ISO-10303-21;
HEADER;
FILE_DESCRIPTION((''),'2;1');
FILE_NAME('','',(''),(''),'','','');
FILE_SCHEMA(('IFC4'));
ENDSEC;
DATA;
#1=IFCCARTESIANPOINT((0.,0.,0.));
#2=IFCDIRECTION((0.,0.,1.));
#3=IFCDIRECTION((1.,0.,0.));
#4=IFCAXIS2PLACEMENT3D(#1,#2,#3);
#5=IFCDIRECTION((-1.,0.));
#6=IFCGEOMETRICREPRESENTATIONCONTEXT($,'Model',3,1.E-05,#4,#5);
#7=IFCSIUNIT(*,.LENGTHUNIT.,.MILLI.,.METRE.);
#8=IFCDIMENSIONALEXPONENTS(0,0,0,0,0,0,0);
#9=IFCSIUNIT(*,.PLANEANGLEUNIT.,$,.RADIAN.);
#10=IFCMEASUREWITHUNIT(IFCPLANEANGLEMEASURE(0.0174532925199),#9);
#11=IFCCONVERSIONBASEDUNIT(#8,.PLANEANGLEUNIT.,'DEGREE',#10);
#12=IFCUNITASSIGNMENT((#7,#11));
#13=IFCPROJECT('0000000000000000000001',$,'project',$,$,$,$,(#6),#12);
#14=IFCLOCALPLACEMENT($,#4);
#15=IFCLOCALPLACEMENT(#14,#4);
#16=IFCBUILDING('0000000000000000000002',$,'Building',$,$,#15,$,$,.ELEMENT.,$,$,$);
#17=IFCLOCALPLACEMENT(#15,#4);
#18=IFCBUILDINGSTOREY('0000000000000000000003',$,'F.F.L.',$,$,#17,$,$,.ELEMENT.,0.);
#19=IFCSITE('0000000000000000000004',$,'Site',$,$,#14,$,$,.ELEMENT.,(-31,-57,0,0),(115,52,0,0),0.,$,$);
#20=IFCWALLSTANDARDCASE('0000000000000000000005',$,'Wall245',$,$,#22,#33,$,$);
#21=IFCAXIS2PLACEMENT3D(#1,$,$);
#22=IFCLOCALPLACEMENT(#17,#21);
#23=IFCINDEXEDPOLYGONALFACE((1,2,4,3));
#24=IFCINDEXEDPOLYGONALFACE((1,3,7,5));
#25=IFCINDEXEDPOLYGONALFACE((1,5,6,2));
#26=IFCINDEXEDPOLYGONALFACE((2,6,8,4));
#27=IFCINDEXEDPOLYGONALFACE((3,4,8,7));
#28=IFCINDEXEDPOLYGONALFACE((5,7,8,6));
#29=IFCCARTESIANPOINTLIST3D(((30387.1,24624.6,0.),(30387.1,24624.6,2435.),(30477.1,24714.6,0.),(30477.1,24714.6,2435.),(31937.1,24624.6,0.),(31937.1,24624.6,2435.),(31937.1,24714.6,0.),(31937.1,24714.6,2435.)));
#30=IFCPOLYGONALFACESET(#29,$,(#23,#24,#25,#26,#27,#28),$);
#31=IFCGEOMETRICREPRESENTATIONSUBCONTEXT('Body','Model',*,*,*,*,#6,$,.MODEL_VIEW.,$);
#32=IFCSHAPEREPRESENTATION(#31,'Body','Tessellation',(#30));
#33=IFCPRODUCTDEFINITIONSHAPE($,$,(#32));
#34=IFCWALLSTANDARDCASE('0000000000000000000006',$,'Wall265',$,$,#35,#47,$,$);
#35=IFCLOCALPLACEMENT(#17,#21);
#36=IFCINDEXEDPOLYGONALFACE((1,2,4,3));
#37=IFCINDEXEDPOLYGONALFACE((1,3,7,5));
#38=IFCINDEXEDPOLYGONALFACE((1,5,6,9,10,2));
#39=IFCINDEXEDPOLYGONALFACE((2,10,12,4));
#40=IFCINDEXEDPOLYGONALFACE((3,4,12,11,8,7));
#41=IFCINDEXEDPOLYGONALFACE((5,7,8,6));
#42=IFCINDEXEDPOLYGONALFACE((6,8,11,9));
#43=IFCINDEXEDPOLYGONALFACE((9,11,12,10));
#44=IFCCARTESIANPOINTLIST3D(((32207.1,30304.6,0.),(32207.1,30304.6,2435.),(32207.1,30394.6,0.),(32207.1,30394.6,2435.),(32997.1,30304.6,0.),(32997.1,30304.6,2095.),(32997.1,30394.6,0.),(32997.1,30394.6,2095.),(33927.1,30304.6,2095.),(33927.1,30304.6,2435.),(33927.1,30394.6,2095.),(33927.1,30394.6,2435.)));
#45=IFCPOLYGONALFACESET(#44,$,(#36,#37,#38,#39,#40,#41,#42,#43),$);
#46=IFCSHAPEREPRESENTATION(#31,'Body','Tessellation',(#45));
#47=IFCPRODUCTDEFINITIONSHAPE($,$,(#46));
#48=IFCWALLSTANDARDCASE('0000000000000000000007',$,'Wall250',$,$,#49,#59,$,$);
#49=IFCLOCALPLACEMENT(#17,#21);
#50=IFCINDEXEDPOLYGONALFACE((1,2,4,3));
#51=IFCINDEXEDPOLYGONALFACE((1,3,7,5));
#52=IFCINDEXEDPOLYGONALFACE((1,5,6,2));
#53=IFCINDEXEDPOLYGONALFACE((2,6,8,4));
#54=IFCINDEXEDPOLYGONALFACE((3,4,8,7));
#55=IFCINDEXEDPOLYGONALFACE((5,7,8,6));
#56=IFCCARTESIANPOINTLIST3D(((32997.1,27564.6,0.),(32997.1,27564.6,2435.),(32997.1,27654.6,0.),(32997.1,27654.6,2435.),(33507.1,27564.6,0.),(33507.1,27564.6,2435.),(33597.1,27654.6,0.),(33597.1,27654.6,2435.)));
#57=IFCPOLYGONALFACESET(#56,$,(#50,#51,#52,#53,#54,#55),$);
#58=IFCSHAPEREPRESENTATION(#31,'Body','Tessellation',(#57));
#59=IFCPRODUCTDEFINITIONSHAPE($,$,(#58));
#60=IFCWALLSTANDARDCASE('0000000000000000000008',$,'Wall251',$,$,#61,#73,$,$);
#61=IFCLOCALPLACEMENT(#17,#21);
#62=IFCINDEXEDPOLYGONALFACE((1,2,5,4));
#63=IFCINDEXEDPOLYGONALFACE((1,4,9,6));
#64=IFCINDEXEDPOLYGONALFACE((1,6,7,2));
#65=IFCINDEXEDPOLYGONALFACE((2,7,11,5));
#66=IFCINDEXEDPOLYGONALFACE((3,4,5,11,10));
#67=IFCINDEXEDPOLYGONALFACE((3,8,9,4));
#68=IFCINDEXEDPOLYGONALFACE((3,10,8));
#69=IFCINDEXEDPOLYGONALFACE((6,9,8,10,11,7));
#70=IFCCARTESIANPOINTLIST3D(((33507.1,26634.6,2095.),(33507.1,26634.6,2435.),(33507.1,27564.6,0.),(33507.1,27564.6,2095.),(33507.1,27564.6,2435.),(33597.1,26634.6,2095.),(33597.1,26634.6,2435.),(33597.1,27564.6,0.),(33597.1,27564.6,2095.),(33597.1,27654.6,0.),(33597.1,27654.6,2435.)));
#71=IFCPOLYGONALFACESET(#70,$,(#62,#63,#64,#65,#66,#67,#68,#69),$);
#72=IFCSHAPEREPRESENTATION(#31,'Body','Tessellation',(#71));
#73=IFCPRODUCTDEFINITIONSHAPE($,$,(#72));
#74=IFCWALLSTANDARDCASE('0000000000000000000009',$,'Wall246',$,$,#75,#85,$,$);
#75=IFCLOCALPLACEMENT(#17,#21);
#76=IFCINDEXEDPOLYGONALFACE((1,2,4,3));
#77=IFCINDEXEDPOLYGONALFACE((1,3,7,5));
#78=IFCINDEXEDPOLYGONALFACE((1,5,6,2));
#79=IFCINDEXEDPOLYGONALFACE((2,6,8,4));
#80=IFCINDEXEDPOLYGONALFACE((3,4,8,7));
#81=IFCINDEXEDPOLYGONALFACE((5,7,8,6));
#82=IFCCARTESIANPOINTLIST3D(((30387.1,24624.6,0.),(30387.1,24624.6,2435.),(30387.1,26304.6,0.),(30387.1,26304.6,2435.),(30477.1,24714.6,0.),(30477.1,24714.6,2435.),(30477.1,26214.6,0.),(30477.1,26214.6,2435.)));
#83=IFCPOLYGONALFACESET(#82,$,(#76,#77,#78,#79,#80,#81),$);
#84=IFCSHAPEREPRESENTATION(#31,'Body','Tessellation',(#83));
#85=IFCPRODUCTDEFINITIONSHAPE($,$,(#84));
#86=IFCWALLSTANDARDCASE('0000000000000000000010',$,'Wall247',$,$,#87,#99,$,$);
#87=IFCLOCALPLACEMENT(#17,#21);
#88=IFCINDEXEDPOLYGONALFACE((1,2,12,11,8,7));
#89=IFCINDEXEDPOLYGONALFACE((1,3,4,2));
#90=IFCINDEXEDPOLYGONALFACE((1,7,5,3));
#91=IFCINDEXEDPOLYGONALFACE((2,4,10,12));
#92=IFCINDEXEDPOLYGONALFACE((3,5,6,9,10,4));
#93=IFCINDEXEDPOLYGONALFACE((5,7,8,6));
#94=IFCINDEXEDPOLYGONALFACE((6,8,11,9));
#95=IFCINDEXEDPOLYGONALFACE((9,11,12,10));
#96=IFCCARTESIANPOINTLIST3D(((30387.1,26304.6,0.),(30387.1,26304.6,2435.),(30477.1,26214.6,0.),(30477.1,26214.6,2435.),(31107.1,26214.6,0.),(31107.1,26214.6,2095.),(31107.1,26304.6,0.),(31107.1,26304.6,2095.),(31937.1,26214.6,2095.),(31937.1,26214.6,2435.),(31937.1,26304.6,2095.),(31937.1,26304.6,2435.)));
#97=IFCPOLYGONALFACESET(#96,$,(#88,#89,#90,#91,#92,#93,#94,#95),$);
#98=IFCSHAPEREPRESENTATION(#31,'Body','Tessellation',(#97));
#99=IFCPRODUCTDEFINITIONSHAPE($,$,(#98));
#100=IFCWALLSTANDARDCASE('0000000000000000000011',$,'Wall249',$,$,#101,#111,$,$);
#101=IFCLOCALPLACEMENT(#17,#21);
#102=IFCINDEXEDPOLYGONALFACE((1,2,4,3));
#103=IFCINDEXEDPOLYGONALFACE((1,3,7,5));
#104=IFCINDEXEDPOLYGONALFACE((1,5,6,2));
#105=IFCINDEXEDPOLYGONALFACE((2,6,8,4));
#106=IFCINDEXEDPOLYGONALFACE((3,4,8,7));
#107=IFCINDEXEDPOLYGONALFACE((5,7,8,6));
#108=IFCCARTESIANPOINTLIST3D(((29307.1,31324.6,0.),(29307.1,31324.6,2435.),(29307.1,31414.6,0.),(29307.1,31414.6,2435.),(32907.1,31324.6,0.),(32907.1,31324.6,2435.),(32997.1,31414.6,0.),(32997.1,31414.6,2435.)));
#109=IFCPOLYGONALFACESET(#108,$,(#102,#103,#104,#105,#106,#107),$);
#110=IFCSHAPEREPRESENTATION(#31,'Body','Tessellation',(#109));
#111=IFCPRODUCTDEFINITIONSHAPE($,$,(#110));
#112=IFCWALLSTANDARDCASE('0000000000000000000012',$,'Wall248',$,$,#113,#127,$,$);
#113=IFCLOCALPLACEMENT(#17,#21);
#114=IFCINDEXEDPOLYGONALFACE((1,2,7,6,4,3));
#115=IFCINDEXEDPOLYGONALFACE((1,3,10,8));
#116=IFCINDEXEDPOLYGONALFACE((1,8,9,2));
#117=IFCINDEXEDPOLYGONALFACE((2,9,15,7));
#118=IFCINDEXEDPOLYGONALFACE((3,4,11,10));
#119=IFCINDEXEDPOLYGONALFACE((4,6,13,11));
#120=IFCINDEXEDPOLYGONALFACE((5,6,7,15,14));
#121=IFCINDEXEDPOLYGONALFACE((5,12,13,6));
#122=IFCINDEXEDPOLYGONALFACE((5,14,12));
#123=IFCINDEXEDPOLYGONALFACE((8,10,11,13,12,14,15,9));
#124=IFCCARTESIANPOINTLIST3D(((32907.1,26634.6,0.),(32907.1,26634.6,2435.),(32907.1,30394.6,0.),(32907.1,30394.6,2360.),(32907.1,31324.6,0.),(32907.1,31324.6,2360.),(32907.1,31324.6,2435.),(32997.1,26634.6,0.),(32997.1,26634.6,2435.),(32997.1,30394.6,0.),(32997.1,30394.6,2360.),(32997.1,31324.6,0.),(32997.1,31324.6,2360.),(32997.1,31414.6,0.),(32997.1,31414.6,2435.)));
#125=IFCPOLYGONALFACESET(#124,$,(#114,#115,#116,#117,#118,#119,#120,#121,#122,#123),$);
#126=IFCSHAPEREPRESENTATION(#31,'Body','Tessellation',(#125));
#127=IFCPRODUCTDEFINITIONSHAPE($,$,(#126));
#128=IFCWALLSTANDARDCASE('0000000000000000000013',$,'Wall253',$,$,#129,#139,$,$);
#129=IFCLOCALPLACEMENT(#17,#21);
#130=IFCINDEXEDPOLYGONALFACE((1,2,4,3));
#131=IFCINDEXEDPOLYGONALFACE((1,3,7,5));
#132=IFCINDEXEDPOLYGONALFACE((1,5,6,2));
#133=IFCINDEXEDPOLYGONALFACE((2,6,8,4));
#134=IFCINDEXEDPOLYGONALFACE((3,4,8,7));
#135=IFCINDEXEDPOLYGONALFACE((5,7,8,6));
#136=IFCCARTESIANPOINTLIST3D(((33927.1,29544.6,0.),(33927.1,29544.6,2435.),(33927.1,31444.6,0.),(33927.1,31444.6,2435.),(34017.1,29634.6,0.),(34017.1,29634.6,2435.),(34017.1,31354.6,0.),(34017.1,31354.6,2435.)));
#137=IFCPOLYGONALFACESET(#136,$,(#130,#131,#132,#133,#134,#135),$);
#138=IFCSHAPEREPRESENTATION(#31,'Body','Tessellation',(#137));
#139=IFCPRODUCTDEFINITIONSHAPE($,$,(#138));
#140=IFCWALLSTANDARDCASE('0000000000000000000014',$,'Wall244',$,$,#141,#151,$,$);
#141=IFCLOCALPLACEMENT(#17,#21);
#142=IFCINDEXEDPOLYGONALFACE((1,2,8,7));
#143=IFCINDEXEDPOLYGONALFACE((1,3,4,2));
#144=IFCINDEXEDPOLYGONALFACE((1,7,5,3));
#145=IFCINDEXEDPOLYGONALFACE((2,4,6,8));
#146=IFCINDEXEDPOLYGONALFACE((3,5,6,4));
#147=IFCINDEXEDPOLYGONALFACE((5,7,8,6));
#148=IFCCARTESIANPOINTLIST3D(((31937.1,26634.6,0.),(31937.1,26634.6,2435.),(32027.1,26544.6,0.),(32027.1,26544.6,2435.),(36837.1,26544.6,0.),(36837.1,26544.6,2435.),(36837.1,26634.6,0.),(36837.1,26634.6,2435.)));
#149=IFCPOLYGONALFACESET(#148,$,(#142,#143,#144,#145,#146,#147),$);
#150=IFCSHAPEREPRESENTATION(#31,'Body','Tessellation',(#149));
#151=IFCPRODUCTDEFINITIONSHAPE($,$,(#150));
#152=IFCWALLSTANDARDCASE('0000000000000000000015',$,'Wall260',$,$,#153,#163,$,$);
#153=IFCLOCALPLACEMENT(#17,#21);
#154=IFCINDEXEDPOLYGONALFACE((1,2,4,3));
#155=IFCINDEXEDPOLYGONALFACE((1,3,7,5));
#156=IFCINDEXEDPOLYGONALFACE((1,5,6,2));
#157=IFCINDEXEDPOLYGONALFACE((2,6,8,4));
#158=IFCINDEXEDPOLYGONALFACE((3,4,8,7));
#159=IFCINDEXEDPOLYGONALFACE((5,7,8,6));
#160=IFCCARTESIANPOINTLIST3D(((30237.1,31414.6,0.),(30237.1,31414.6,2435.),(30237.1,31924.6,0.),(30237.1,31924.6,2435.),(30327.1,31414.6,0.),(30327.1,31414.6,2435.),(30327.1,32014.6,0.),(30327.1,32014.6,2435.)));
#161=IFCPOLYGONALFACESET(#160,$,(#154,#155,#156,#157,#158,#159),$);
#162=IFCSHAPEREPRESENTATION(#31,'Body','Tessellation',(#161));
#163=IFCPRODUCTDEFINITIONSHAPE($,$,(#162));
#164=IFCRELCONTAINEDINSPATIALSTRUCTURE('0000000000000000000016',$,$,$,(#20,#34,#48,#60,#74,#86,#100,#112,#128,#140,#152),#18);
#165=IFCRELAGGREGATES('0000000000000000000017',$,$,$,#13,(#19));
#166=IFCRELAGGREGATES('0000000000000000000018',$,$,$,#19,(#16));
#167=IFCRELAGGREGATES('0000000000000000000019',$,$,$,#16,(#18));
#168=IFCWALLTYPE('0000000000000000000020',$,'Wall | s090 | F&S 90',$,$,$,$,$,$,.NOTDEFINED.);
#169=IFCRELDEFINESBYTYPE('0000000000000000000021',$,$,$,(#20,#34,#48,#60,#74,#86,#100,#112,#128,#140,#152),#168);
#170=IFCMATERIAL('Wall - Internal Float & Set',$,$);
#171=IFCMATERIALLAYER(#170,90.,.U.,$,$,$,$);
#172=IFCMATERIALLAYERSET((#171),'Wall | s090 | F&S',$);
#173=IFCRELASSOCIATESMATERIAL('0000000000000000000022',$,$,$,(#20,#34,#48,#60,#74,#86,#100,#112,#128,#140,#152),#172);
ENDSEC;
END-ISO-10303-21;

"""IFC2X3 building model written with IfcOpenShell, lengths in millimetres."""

from ifc_helpers import new_model, entity, si_unit, converted_unit, direction, frame, origin_with_axes, origin_2d_with_axis, place, context, subcontext, project, spatial, polyline, rectangle, outline, extrude, material, layer, layer_set, layer_usage, type_object, element, save


model = new_model("IFC2X3")

# Units and contexts
model_context = context("Model", 3, precision=1e-05, world=origin_with_axes(), true_north=direction((-1.0, 0.0)))
body_context = subcontext(model_context, "Body", "Model", "MODEL_VIEW")
ifc_project = project(units=[si_unit("LENGTHUNIT", "METRE", prefix="MILLI"), converted_unit("PLANEANGLEUNIT", "DEGREE", entity("IfcPlaneAngleMeasure", 0.0174532925199), si_unit("PLANEANGLEUNIT", "RADIAN"), dimensions=[0, 0, 0, 0, 0, 0, 0])], contexts=[model_context])

# Site, building, storey
site_placement = place(None, origin_with_axes())
site = spatial("IfcSite", under=ifc_project, at=site_placement, Name="Site", CompositionType="ELEMENT", RefLatitude=(-31, -57, 0, 0), RefLongitude=(115, 52, 0, 0), RefElevation=0.0)
building_placement = place(site_placement, origin_with_axes())
building = spatial("IfcBuilding", under=site, at=building_placement, Name="Building", CompositionType="ELEMENT")
storey_placement = place(building_placement, origin_with_axes())
storey = spatial("IfcBuildingStorey", under=building, at=storey_placement, Name="F.F.L.", CompositionType="ELEMENT", Elevation=0.0)

# Wall
ifc_material_1 = material(Name="Wall - Internal Float & Set")
ifc_layer = layer(ifc_material_1, 90.0, ventilated="UNKNOWN")
ifc_layer_set = layer_set([ifc_layer], Name="Wall | s090 | F&S")
ifc_layer_usage_1 = layer_usage(ifc_layer_set, "AXIS2", "POSITIVE", -90.0)
wall_type = type_object("IfcWallType", Name="Wall | s090 | F&S 90", PredefinedType="NOTDEFINED")
wall_1_placement = place(storey_placement, frame((31937.1, 24624.6, 0.0), z_axis=(0.0, 0.0, 1.0), x_axis=(-1.0, 0.0, 0.0)))
element("IfcWallStandardCase", 1, at=wall_1_placement, inside=storey, type_object=wall_type, material=ifc_layer_usage_1, Name="Wall245", context=body_context, shape_type="SweptSolid", body=[
    extrude(outline(polyline([(0.0, -90.0), (1460.0, -90.0), (1550.0, 0.0), (0.0, 0.0), (0.0, -90.0)])), origin_with_axes(), (0.0, 0.0, 1.0), 2435.0),
])

# Wall, opening
ifc_layer_usage_2 = layer_usage(ifc_layer_set, "AXIS2", "POSITIVE", -90.0)
wall_2_placement = place(storey_placement, frame((32207.1, 30394.6, 0.0), z_axis=(0.0, 0.0, 1.0), x_axis=(1.0, 0.0, 0.0)))
wall_2 = element("IfcWallStandardCase", 2, at=wall_2_placement, inside=storey, type_object=wall_type, material=ifc_layer_usage_2, Name="Wall265", context=body_context, shape_type="SweptSolid", body=[
    extrude(outline(polyline([(0.0, -90.0), (1720.0, -90.0), (1720.0, 0.0), (0.0, 0.0), (0.0, -90.0)])), origin_with_axes(), (0.0, 0.0, 1.0), 2435.0),
])
opening_1_placement = place(wall_2_placement, frame((1255.0, 0.0, 0.0), z_axis=(0.0, 0.0, 1.0), x_axis=(1.0, 0.0, 0.0)))
element("IfcOpeningElement", 3, at=opening_1_placement, cuts=wall_2, context=body_context, shape_type="SweptSolid", body=[
    extrude(rectangle(XDim=930.0, YDim=2095.0, at=origin_2d_with_axis()), frame((0.0, 90.0, 1047.5), z_axis=(0.0, -1.0, 0.0), x_axis=(-1.0, 0.0, 0.0)), (0.0, 0.0, 1.0), 180.0),
])

# Wall
ifc_layer_usage_3 = layer_usage(ifc_layer_set, "AXIS2", "POSITIVE", -90.0)
wall_3_placement = place(storey_placement, frame((32907.1, 27654.6, 0.0), z_axis=(0.0, 0.0, 1.0), x_axis=(1.0, 0.0, 0.0)))
element("IfcWallStandardCase", 4, at=wall_3_placement, inside=storey, type_object=wall_type, material=ifc_layer_usage_3, Name="Wall250", context=body_context, shape_type="SweptSolid", body=[
    extrude(outline(polyline([(90.0, -90.0), (600.0, -90.0), (690.0, 0.0), (90.0, 0.0), (90.0, -90.0)])), origin_with_axes(), (0.0, 0.0, 1.0), 2435.0),
])

# Wall, opening
ifc_layer_usage_4 = layer_usage(ifc_layer_set, "AXIS2", "POSITIVE", -90.0)
wall_4_placement = place(storey_placement, frame((33597.1, 27654.6, 0.0), z_axis=(0.0, 0.0, 1.0), x_axis=(0.0, -1.0, 0.0)))
wall_4 = element("IfcWallStandardCase", 5, at=wall_4_placement, inside=storey, type_object=wall_type, material=ifc_layer_usage_4, Name="Wall251", context=body_context, shape_type="SweptSolid", body=[
    extrude(outline(polyline([(90.0, -90.0), (1020.0, -90.0), (1020.0, 0.0), (0.0, 0.0), (90.0, -90.0)])), origin_with_axes(), (0.0, 0.0, 1.0), 2435.0),
])
opening_2_placement = place(wall_4_placement, frame((555.0, 0.0, 0.0), z_axis=(0.0, 0.0, 1.0), x_axis=(1.0, 0.0, 0.0)))
element("IfcOpeningElement", 6, at=opening_2_placement, cuts=wall_4, context=body_context, shape_type="SweptSolid", body=[
    extrude(rectangle(XDim=930.0, YDim=2095.0, at=origin_2d_with_axis()), frame((0.0, -90.0, 1047.5), z_axis=(0.0, 1.0, 0.0), x_axis=(1.0, 0.0, 0.0)), (0.0, 0.0, 1.0), 180.0),
])

# Wall
ifc_layer_usage_5 = layer_usage(ifc_layer_set, "AXIS2", "POSITIVE", -90.0)
wall_5_placement = place(storey_placement, frame((30387.1, 24624.6, 0.0), z_axis=(0.0, 0.0, 1.0), x_axis=(0.0, 1.0, 0.0)))
element("IfcWallStandardCase", 7, at=wall_5_placement, inside=storey, type_object=wall_type, material=ifc_layer_usage_5, Name="Wall246", context=body_context, shape_type="SweptSolid", body=[
    extrude(outline(polyline([(90.0, -90.0), (1590.0, -90.0), (1680.0, 0.0), (0.0, 0.0), (90.0, -90.0)])), origin_with_axes(), (0.0, 0.0, 1.0), 2435.0),
])

# Wall, opening
ifc_layer_usage_6 = layer_usage(ifc_layer_set, "AXIS2", "POSITIVE", -90.0)
wall_6_placement = place(storey_placement, frame((30387.1, 26304.6, 0.0), z_axis=(0.0, 0.0, 1.0), x_axis=(1.0, 0.0, 0.0)))
wall_6 = element("IfcWallStandardCase", 8, at=wall_6_placement, inside=storey, type_object=wall_type, material=ifc_layer_usage_6, Name="Wall247", context=body_context, shape_type="SweptSolid", body=[
    extrude(outline(polyline([(90.0, -90.0), (1550.0, -90.0), (1550.0, 0.0), (0.0, 0.0), (90.0, -90.0)])), origin_with_axes(), (0.0, 0.0, 1.0), 2435.0),
])
opening_3_placement = place(wall_6_placement, frame((1135.0, 0.0, 0.0), z_axis=(0.0, 0.0, 1.0), x_axis=(1.0, 0.0, 0.0)))
element("IfcOpeningElement", 9, at=opening_3_placement, cuts=wall_6, context=body_context, shape_type="SweptSolid", body=[
    extrude(rectangle(XDim=830.0, YDim=2095.0, at=origin_2d_with_axis()), frame((0.0, 90.0, 1047.5), z_axis=(0.0, 1.0, 0.0), x_axis=(1.0, 0.0, 0.0)), (0.0, 0.0, -1.0), 180.0),
])

# Wall
ifc_layer_usage_7 = layer_usage(ifc_layer_set, "AXIS2", "POSITIVE", -90.0)
wall_7_placement = place(storey_placement, frame((32907.1, 31324.6, 0.0), z_axis=(0.0, 0.0, 1.0), x_axis=(-1.0, 0.0, 0.0)))
element("IfcWallStandardCase", 10, at=wall_7_placement, inside=storey, type_object=wall_type, material=ifc_layer_usage_7, Name="Wall249", context=body_context, shape_type="SweptSolid", body=[
    extrude(outline(polyline([(-90.0, -90.0), (3600.0, -90.0), (3600.0, 0.0), (0.0, 0.0), (-90.0, -90.0)])), origin_with_axes(), (0.0, 0.0, 1.0), 2435.0),
])

# Wall, opening
ifc_layer_usage_8 = layer_usage(ifc_layer_set, "AXIS2", "POSITIVE", -90.0)
wall_8_placement = place(storey_placement, frame((32907.1, 26634.6, 0.0), z_axis=(0.0, 0.0, 1.0), x_axis=(0.0, 1.0, 0.0)))
wall_8 = element("IfcWallStandardCase", 11, at=wall_8_placement, inside=storey, type_object=wall_type, material=ifc_layer_usage_8, Name="Wall248", context=body_context, shape_type="SweptSolid", body=[
    extrude(outline(polyline([(0.0, -90.0), (4780.0, -90.0), (4690.0, 0.0), (0.0, 0.0), (0.0, -90.0)])), origin_with_axes(), (0.0, 0.0, 1.0), 2435.0),
])
opening_4_placement = place(wall_8_placement, frame((4225.0, 0.0, 0.0), z_axis=(0.0, 0.0, 1.0), x_axis=(1.0, 0.0, 0.0)))
element("IfcOpeningElement", 12, at=opening_4_placement, cuts=wall_8, context=body_context, shape_type="SweptSolid", body=[
    extrude(rectangle(XDim=930.0, YDim=2360.0, at=origin_2d_with_axis()), frame((0.0, -90.0, 1180.0), z_axis=(0.0, 1.0, 0.0), x_axis=(1.0, 0.0, 0.0)), (0.0, 0.0, 1.0), 180.0),
])

# Walls
ifc_layer_usage_9 = layer_usage(ifc_layer_set, "AXIS2", "POSITIVE", -90.0)
wall_9_placement = place(storey_placement, frame((33927.1, 29544.6, 0.0), z_axis=(0.0, 0.0, 1.0), x_axis=(0.0, 1.0, 0.0)))
element("IfcWallStandardCase", 13, at=wall_9_placement, inside=storey, type_object=wall_type, material=ifc_layer_usage_9, Name="Wall253", context=body_context, shape_type="SweptSolid", body=[
    extrude(outline(polyline([(90.0, -90.0), (1810.0, -90.0), (1900.0, 0.0), (0.0, 0.0), (90.0, -90.0)])), origin_with_axes(), (0.0, 0.0, 1.0), 2435.0),
])
ifc_layer_usage_10 = layer_usage(ifc_layer_set, "AXIS2", "POSITIVE", -90.0)
wall_10_placement = place(storey_placement, frame((31937.1, 26634.6, 0.0), z_axis=(0.0, 0.0, 1.0), x_axis=(1.0, 0.0, 0.0)))
element("IfcWallStandardCase", 14, at=wall_10_placement, inside=storey, type_object=wall_type, material=ifc_layer_usage_10, Name="Wall244", context=body_context, shape_type="SweptSolid", body=[
    extrude(outline(polyline([(90.0, -90.0), (4900.0, -90.0), (4900.0, 0.0), (0.0, 0.0), (90.0, -90.0)])), origin_with_axes(), (0.0, 0.0, 1.0), 2435.0),
])
ifc_layer_usage_11 = layer_usage(ifc_layer_set, "AXIS2", "NEGATIVE", 90.0)
wall_11_placement = place(storey_placement, frame((30327.1, 31324.6, 0.0), z_axis=(0.0, 0.0, 1.0), x_axis=(0.0, 1.0, 0.0)))
element("IfcWallStandardCase", 15, at=wall_11_placement, inside=storey, type_object=wall_type, material=ifc_layer_usage_11, Name="Wall260", context=body_context, shape_type="SweptSolid", body=[
    extrude(outline(polyline([(90.0, 0.0), (690.0, 0.0), (600.0, 90.0), (90.0, 90.0), (90.0, 0.0)])), origin_with_axes(), (0.0, 0.0, 1.0), 2435.0),
])

save(model, "model.ifc")
